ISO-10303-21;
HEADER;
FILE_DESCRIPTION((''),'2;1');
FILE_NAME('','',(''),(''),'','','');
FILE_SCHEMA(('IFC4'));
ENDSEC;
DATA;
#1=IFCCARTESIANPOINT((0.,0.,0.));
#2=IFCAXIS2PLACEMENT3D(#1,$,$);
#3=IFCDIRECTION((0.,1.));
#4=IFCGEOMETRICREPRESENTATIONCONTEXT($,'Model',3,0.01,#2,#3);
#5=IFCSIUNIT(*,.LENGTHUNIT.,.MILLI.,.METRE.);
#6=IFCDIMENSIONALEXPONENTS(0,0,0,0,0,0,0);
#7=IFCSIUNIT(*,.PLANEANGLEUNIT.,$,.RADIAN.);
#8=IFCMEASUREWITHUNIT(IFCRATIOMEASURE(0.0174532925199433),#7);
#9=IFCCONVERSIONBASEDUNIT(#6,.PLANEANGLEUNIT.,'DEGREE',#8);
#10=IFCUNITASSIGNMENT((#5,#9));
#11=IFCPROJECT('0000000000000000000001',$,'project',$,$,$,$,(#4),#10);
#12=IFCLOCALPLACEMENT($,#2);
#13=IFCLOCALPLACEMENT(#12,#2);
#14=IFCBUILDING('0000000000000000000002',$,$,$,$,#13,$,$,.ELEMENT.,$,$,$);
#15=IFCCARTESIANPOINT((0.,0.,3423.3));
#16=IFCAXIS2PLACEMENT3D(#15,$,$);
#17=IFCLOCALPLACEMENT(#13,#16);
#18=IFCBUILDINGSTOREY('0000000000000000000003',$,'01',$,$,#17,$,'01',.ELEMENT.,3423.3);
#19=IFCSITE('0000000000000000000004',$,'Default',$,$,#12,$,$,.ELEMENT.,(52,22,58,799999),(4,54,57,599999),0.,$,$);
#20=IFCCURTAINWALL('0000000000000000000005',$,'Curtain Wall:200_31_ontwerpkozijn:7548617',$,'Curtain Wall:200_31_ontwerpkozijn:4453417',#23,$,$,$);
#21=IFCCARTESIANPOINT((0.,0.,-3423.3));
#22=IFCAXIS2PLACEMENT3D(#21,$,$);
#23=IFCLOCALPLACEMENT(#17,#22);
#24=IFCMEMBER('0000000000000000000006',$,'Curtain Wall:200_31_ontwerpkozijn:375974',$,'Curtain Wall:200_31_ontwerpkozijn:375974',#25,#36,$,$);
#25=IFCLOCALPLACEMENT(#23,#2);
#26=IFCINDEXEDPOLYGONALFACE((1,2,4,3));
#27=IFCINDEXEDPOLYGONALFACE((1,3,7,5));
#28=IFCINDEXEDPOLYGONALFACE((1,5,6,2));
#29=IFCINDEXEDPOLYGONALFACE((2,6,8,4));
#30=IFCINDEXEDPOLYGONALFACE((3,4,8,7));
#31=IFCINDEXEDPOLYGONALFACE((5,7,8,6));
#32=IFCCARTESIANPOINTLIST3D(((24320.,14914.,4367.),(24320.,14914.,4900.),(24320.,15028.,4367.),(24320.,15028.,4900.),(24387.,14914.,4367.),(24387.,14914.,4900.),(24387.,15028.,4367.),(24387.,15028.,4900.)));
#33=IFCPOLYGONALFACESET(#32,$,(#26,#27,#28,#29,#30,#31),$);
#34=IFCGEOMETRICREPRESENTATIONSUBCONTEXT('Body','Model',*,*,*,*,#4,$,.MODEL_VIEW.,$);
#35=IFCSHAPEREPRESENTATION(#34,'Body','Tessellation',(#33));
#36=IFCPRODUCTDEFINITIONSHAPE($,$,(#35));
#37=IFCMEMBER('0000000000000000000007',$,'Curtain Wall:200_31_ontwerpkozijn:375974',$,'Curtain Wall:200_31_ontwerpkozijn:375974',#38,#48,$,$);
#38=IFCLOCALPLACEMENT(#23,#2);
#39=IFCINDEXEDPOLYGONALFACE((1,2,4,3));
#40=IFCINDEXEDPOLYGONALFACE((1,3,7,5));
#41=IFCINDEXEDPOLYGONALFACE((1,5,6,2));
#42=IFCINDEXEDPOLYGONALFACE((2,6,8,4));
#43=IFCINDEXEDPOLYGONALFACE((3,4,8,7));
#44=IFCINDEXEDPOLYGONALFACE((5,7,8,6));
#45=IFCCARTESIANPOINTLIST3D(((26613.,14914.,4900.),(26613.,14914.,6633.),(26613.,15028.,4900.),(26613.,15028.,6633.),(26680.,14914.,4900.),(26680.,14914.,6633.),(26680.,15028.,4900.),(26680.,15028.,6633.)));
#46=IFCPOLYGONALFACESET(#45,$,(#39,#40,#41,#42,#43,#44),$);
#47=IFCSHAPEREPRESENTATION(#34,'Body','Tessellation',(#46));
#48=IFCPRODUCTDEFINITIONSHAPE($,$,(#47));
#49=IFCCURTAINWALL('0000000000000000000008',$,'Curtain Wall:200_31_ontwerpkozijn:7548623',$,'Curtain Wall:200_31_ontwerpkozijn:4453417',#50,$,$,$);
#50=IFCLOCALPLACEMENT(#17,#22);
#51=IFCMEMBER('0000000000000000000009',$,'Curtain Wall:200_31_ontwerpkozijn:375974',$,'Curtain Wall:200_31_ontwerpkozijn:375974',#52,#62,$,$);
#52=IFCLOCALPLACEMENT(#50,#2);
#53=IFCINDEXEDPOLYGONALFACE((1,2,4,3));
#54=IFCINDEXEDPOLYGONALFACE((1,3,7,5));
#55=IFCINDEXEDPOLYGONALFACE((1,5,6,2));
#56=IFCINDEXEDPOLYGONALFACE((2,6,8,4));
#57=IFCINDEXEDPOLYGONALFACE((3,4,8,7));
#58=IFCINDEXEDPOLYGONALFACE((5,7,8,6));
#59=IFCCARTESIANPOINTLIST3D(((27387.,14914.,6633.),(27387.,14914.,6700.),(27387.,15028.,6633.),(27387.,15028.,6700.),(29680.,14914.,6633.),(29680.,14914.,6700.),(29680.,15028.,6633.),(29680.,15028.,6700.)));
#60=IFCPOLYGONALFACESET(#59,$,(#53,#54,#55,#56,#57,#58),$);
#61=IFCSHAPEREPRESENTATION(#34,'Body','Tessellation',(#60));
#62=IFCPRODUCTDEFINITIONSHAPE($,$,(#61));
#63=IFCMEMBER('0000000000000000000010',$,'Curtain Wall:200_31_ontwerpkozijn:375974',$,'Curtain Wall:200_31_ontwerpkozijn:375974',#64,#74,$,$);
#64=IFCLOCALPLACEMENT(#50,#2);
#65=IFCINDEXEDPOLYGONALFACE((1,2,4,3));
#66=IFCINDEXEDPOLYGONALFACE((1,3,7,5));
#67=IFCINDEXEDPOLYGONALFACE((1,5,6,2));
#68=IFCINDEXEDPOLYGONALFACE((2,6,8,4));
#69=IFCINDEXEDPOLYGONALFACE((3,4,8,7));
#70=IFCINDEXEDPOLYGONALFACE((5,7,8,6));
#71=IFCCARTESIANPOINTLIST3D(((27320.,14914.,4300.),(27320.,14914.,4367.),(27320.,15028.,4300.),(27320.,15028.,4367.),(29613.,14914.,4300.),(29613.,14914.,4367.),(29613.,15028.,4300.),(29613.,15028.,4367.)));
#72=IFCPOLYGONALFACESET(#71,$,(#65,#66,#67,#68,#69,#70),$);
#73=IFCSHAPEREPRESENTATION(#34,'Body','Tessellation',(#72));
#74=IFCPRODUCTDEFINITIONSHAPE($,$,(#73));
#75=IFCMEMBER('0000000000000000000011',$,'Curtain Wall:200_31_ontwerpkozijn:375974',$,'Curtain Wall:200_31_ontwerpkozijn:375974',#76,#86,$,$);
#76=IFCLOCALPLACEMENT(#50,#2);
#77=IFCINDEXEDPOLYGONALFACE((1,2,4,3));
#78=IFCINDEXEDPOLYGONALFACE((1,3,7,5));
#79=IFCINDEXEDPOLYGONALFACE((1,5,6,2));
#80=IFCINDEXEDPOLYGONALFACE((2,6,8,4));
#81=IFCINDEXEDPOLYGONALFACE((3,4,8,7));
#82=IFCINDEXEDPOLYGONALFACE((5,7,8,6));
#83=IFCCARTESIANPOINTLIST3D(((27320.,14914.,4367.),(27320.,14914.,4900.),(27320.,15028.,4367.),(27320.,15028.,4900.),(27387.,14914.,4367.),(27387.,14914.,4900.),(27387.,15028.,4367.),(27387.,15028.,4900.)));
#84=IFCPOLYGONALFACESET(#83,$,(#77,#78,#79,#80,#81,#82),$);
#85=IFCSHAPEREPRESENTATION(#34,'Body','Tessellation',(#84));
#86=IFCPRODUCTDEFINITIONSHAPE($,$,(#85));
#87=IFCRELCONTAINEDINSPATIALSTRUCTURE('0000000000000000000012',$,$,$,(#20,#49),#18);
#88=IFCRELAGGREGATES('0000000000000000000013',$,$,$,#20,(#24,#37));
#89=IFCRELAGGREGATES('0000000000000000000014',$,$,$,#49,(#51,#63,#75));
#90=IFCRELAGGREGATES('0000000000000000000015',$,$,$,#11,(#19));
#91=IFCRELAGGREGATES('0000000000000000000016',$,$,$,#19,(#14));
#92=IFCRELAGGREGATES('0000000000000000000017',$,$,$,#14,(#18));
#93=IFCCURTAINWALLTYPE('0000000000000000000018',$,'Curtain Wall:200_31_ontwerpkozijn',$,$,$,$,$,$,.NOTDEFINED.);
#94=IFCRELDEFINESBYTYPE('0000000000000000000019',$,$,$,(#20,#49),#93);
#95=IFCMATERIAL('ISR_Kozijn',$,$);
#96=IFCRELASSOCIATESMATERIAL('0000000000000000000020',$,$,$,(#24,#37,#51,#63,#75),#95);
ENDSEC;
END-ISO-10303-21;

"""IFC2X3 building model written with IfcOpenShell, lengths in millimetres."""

from ifc_helpers import new_model, entity, si_unit, converted_unit, direction, frame, frame_2d, origin, origin_2d_with_axis, place, context, subcontext, project, spatial, rectangle, extrude, material, type_object, element, aggregate, save


model = new_model("IFC2X3")

# Units and contexts
model_context = context("Model", 3, precision=0.01, world=origin(), true_north=direction((0.0, 1.0)))
body_context = subcontext(model_context, "Body", "Model", "MODEL_VIEW")
ifc_project = project(units=[si_unit("LENGTHUNIT", "METRE", prefix="MILLI"), converted_unit("PLANEANGLEUNIT", "DEGREE", entity("IfcRatioMeasure", 0.0174532925199433), si_unit("PLANEANGLEUNIT", "RADIAN"), dimensions=[0, 0, 0, 0, 0, 0, 0])], contexts=[model_context])

# Site, building, storey
site_placement = place(None, origin())
site = spatial("IfcSite", under=ifc_project, at=site_placement, Name="Default", CompositionType="ELEMENT", RefLatitude=(52, 22, 58, 799999), RefLongitude=(4, 54, 57, 599999), RefElevation=0.0)
building_placement = place(site_placement, origin())
building = spatial("IfcBuilding", under=site, at=building_placement, CompositionType="ELEMENT")
storey_placement = place(building_placement, frame((0.0, 0.0, 3423.3)))
storey = spatial("IfcBuildingStorey", under=building, at=storey_placement, Name="01", LongName="01", CompositionType="ELEMENT", Elevation=3423.3)

# Curtain walls, members
curtain_wall_type = type_object("IfcCurtainWallType", Name="Curtain Wall:200_31_ontwerpkozijn", PredefinedType="NOTDEFINED")
ifc_material_1 = material(Name="ISR_Kozijn")
curtain_wall_1_placement = place(storey_placement, frame((0.0, 0.0, -3423.3)))
curtain_wall_1 = element("IfcCurtainWall", 1, at=curtain_wall_1_placement, inside=storey, type_object=curtain_wall_type, Name="Curtain Wall:200_31_ontwerpkozijn:7548617", ObjectType="Curtain Wall:200_31_ontwerpkozijn:4453417")
member_1_placement = place(curtain_wall_1_placement, origin())
member_1 = element("IfcMember", 2, at=member_1_placement, material=ifc_material_1, Name="Curtain Wall:200_31_ontwerpkozijn:375974", ObjectType="Curtain Wall:200_31_ontwerpkozijn:375974", context=body_context, shape_type="SweptSolid", body=[
    extrude(rectangle(XDim=67.0, YDim=114.0, at=origin_2d_with_axis()), frame((24353.5, 14971.0, 4367.0), z_axis=(0.0, 0.0, 1.0), x_axis=(-1.0, 0.0, 0.0)), (0.0, 0.0, 1.0), 533.0),
])
member_2_placement = place(curtain_wall_1_placement, origin())
member_2 = element("IfcMember", 3, at=member_2_placement, material=ifc_material_1, Name="Curtain Wall:200_31_ontwerpkozijn:375974", ObjectType="Curtain Wall:200_31_ontwerpkozijn:375974", context=body_context, shape_type="SweptSolid", body=[
    extrude(rectangle(XDim=67.0, YDim=114.0, at=origin_2d_with_axis()), frame((26646.5, 14971.0, 6633.0), z_axis=(0.0, 0.0, -1.0), x_axis=(-1.0, 0.0, 0.0)), (0.0, 0.0, 1.0), 1733.0),
])
aggregate(curtain_wall_1, [member_1, member_2])
curtain_wall_2_placement = place(storey_placement, frame((0.0, 0.0, -3423.3)))
curtain_wall_2 = element("IfcCurtainWall", 4, at=curtain_wall_2_placement, inside=storey, type_object=curtain_wall_type, Name="Curtain Wall:200_31_ontwerpkozijn:7548623", ObjectType="Curtain Wall:200_31_ontwerpkozijn:4453417")
member_3_placement = place(curtain_wall_2_placement, origin())
member_3 = element("IfcMember", 5, at=member_3_placement, material=ifc_material_1, Name="Curtain Wall:200_31_ontwerpkozijn:375974", ObjectType="Curtain Wall:200_31_ontwerpkozijn:375974", context=body_context, shape_type="SweptSolid", body=[
    extrude(rectangle(XDim=67.0, YDim=114.0, at=frame_2d((0.0, 0.0), x_axis=(1.0, 0.0))), frame((27387.0, 14971.0, 6666.5), z_axis=(1.0, 0.0, 0.0), x_axis=(0.0, 0.0, -1.0)), (0.0, 0.0, 1.0), 2293.0),
])
member_4_placement = place(curtain_wall_2_placement, origin())
member_4 = element("IfcMember", 6, at=member_4_placement, material=ifc_material_1, Name="Curtain Wall:200_31_ontwerpkozijn:375974", ObjectType="Curtain Wall:200_31_ontwerpkozijn:375974", context=body_context, shape_type="SweptSolid", body=[
    extrude(rectangle(XDim=67.0, YDim=114.0, at=frame_2d((0.0, 0.0), x_axis=(1.0, 0.0))), frame((29613.0, 14971.0, 4333.5), z_axis=(-1.0, 0.0, 0.0), x_axis=(0.0, 0.0, -1.0)), (0.0, 0.0, 1.0), 2293.0),
])
member_5_placement = place(curtain_wall_2_placement, origin())
member_5 = element("IfcMember", 7, at=member_5_placement, material=ifc_material_1, Name="Curtain Wall:200_31_ontwerpkozijn:375974", ObjectType="Curtain Wall:200_31_ontwerpkozijn:375974", context=body_context, shape_type="SweptSolid", body=[
    extrude(rectangle(XDim=67.0, YDim=114.0, at=origin_2d_with_axis()), frame((27353.5, 14971.0, 4367.0), z_axis=(0.0, 0.0, 1.0), x_axis=(-1.0, 0.0, 0.0)), (0.0, 0.0, 1.0), 533.0),
])
aggregate(curtain_wall_2, [member_3, member_4, member_5])

save(model, "model.ifc")
